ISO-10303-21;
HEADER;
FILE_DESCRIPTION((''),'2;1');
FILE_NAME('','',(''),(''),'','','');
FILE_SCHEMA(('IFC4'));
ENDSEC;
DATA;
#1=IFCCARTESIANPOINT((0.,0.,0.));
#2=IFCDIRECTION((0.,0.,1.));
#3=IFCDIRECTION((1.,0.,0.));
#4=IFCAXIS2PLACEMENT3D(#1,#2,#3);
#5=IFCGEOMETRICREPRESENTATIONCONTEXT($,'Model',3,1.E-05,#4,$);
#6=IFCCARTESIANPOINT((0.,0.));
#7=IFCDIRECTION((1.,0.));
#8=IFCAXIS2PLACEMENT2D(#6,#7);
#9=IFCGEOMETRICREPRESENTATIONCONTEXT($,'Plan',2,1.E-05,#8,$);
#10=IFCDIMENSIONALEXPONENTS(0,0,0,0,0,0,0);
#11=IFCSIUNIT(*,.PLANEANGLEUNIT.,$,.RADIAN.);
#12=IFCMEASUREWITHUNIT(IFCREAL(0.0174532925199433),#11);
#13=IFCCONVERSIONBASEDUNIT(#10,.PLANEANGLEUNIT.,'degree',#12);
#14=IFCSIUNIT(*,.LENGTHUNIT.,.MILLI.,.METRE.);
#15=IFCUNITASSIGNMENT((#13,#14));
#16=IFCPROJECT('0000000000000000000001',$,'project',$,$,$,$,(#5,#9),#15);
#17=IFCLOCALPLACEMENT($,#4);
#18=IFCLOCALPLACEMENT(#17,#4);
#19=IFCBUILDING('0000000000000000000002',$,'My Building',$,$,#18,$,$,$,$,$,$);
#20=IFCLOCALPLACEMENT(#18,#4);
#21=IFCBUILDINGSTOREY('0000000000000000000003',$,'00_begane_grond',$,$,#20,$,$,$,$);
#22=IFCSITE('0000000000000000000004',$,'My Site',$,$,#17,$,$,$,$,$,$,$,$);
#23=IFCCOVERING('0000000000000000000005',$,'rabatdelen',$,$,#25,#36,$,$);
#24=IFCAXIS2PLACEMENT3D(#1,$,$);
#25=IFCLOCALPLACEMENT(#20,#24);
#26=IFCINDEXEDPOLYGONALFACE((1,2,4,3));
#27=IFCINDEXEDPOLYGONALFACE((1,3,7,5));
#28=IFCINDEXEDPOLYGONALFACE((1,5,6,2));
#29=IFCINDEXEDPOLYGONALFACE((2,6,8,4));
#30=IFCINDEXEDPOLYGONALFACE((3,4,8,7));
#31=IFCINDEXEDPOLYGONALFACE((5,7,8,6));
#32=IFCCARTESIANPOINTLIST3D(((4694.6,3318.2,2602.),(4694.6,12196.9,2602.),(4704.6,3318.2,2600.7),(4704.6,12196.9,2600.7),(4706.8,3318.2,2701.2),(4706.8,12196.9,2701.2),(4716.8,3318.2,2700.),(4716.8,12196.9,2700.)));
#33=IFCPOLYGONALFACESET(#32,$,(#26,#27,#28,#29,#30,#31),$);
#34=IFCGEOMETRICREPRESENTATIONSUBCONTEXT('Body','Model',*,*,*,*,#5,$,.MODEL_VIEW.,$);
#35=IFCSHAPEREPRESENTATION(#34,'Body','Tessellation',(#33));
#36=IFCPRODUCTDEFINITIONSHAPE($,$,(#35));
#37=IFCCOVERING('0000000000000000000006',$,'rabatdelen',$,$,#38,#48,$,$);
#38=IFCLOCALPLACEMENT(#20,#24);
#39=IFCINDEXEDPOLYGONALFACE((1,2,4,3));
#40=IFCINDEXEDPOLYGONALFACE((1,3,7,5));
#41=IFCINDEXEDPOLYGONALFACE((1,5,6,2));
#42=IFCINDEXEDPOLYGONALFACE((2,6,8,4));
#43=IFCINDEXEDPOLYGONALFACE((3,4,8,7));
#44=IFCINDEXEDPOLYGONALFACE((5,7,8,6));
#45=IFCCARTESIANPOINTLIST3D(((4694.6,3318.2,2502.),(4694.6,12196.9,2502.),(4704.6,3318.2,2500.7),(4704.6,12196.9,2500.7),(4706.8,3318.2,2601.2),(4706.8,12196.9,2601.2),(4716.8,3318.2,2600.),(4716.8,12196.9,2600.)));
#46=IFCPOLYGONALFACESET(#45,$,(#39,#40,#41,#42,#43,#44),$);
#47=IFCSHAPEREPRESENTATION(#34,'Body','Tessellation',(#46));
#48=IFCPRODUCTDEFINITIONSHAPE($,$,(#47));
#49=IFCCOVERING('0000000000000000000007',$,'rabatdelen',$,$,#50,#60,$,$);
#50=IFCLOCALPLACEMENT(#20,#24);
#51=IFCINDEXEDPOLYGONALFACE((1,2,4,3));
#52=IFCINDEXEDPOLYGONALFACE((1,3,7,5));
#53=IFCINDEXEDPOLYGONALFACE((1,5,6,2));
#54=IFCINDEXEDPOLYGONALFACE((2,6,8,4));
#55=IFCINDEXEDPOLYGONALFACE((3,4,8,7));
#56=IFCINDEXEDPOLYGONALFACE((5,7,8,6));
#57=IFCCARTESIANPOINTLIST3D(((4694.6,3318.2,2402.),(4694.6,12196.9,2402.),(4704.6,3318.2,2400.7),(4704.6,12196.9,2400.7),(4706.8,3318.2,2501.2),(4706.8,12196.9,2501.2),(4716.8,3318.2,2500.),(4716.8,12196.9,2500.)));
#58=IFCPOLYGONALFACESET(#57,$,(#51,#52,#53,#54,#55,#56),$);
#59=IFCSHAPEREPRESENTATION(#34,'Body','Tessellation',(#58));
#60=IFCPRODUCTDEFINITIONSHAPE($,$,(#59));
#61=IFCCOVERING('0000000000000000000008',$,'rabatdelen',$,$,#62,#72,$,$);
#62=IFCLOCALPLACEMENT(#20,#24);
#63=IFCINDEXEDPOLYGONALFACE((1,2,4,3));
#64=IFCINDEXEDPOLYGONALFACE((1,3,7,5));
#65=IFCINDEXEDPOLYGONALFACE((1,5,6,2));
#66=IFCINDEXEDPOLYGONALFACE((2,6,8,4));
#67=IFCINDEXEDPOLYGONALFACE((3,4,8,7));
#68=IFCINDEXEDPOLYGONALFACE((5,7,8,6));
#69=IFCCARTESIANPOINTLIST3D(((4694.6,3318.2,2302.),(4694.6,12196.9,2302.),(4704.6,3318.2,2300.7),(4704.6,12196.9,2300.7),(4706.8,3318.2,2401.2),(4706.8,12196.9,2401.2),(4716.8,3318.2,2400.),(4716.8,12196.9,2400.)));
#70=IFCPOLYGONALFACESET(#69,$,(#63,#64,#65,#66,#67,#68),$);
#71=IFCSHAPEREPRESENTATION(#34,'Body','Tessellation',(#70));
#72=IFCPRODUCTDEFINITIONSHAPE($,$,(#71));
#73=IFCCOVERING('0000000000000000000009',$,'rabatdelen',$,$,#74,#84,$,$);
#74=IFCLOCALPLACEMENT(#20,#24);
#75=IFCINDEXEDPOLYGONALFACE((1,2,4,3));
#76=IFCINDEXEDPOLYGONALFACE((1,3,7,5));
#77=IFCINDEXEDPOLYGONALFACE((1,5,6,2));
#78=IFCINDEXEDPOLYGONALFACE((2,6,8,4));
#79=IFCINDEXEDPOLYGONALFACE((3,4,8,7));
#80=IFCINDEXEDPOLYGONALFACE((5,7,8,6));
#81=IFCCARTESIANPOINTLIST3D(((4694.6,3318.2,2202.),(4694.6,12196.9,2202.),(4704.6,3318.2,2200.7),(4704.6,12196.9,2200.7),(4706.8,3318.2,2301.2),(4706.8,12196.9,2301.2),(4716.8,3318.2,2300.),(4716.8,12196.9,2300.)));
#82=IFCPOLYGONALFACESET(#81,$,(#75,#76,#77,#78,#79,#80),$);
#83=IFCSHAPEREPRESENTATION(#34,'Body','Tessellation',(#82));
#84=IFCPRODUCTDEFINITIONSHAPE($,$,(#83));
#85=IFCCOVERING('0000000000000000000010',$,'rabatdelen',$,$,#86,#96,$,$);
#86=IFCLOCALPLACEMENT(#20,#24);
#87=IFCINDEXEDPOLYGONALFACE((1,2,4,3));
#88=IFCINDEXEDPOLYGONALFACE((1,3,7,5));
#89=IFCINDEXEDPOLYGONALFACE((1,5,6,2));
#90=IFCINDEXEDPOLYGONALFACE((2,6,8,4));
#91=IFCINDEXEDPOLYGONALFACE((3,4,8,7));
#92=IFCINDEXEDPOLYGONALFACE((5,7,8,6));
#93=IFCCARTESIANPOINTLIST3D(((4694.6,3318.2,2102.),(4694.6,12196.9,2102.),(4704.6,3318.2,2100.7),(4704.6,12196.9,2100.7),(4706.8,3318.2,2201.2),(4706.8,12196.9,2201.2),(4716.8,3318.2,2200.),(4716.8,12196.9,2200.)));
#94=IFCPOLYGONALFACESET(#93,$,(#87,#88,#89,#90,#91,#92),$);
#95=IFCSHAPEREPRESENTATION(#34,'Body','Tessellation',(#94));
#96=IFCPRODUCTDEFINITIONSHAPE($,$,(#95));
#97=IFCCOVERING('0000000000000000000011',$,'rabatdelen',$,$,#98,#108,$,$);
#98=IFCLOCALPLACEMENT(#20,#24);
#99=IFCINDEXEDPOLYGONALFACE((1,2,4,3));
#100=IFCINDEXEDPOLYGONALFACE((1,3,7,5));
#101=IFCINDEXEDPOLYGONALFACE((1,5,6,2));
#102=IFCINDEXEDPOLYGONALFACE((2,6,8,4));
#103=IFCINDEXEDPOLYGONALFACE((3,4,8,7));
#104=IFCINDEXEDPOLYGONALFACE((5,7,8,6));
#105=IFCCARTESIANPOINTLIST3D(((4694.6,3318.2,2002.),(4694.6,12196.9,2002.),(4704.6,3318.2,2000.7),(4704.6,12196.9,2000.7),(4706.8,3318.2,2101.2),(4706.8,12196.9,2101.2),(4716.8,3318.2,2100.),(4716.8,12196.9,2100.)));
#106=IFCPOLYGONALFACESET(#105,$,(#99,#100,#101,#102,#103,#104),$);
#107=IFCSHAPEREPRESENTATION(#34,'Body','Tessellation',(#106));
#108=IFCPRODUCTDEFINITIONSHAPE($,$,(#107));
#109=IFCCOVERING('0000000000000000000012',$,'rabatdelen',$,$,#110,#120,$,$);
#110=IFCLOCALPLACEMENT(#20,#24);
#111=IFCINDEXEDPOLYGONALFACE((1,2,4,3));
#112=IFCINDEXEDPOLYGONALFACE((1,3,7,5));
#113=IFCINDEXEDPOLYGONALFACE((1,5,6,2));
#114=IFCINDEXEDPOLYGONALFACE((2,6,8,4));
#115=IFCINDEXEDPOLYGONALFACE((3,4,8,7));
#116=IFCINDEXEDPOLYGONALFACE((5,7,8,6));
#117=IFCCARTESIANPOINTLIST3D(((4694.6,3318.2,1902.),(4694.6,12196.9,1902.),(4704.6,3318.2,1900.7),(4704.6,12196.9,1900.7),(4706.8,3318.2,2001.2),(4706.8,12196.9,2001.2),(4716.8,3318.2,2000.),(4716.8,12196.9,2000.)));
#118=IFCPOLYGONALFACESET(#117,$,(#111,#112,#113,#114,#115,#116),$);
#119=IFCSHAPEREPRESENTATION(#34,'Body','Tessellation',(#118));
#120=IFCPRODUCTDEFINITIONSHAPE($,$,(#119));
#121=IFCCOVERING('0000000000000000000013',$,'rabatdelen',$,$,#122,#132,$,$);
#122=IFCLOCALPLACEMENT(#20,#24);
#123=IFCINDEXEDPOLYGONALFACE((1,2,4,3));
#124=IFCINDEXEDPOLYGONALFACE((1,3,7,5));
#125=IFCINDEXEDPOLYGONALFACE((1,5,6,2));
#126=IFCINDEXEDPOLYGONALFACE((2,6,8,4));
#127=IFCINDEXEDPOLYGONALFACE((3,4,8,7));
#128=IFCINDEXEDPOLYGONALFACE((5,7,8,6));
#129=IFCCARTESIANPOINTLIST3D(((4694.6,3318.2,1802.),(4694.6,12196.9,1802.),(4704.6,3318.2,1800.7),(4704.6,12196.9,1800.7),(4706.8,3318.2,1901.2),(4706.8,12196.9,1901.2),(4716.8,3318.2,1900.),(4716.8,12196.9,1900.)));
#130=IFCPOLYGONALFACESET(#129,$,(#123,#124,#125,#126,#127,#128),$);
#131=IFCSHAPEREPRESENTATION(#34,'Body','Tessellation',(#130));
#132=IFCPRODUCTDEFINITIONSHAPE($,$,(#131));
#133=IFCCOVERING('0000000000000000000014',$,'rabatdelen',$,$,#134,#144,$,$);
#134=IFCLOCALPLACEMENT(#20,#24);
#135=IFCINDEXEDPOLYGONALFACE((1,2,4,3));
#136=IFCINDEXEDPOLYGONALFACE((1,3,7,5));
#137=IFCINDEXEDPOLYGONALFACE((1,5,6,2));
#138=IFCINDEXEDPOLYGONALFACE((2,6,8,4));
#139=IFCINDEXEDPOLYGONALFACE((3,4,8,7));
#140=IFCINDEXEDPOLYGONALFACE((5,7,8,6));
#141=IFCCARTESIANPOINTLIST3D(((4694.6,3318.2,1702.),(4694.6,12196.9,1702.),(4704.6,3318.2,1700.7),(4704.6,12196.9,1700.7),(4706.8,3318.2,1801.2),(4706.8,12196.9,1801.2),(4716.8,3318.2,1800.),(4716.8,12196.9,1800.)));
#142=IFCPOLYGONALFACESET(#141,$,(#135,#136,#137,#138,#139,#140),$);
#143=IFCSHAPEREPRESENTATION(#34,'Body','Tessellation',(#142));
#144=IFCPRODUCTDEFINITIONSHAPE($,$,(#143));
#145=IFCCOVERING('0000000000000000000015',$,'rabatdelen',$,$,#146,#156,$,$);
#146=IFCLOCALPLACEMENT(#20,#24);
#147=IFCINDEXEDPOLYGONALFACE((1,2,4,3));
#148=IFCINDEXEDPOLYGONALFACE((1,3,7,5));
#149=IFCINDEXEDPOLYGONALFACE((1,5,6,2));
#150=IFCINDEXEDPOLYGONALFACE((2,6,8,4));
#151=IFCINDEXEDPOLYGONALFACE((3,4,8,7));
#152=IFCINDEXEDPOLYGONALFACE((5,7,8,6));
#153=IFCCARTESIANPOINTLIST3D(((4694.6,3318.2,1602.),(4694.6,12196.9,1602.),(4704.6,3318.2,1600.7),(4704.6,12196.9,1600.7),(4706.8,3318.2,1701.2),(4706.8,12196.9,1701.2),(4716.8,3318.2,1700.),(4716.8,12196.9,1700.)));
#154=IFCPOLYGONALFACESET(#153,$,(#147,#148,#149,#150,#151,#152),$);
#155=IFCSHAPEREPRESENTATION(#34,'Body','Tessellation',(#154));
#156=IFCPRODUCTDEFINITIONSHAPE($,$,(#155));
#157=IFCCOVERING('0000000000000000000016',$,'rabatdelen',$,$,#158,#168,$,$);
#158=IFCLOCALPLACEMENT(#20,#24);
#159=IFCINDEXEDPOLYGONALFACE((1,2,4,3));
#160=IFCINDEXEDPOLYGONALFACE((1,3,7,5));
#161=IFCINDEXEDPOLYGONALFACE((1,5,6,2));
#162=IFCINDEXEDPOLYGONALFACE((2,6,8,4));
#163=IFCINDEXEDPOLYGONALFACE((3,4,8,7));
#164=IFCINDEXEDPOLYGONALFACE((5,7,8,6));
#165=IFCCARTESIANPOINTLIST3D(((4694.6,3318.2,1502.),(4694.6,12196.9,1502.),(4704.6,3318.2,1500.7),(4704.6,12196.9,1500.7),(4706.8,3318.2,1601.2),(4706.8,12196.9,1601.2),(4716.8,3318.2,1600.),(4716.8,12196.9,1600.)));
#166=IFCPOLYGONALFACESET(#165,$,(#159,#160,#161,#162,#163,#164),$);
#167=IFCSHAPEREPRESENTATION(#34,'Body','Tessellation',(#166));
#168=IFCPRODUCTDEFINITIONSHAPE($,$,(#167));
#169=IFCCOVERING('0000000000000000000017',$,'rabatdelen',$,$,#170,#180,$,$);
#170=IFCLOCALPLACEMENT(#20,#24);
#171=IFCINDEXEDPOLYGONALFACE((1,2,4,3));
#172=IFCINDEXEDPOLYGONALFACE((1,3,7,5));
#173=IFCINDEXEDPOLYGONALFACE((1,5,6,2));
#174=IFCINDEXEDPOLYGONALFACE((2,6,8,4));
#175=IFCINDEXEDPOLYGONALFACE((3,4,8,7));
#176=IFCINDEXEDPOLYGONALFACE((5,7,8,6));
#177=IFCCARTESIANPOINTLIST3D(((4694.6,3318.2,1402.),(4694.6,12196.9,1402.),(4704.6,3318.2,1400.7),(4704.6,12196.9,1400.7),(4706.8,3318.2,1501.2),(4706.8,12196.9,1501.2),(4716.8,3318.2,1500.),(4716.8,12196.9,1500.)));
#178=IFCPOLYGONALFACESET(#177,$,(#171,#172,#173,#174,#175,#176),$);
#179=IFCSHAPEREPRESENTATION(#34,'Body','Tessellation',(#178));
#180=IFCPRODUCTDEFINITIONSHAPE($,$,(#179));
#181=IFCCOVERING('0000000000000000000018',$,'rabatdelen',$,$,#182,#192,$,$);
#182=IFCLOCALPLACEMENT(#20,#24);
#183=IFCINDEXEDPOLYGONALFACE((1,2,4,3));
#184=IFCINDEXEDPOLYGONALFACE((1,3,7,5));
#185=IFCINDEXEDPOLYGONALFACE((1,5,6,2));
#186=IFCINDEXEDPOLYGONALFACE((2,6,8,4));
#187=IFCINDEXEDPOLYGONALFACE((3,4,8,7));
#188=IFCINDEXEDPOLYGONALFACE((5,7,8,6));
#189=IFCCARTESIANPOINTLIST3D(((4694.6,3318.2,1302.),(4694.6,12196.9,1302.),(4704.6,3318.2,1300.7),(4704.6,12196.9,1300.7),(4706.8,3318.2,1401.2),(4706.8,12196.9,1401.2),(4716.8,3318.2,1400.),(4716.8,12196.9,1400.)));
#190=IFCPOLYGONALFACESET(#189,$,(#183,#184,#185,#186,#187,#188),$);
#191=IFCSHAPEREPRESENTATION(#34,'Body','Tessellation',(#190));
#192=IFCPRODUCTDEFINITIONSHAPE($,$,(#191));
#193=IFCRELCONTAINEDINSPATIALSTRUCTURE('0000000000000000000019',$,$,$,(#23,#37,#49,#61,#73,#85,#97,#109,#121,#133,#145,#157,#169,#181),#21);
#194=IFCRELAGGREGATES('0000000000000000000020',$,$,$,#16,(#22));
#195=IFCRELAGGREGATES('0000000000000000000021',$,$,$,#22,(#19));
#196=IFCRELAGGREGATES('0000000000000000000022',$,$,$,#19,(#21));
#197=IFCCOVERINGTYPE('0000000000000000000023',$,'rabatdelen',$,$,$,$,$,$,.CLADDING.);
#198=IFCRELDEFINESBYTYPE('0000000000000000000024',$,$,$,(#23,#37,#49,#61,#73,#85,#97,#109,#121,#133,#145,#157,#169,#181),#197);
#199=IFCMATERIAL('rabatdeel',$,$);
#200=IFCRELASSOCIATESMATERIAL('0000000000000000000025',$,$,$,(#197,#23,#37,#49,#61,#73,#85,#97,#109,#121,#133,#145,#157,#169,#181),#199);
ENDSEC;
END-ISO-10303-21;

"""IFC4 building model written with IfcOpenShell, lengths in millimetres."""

from ifc_helpers import new_model, entity, si_unit, converted_unit, frame, origin_with_axes, origin_2d_with_axis, place, context, subcontext, project, spatial, rectangle, extrude, material, material_profile, profile_set, profile_usage, type_object, element, save


model = new_model("IFC4")

# Units and contexts
model_context = context("Model", 3, precision=1e-05, world=origin_with_axes())
plan_context = context("Plan", 2, precision=1e-05, world=origin_2d_with_axis())
body_context = subcontext(model_context, "Body", "Model", "MODEL_VIEW")
ifc_project = project(units=[converted_unit("PLANEANGLEUNIT", "degree", entity("IfcReal", 0.0174532925199433), si_unit("PLANEANGLEUNIT", "RADIAN"), dimensions=[0, 0, 0, 0, 0, 0, 0]), si_unit("LENGTHUNIT", "METRE", prefix="MILLI")], contexts=[model_context, plan_context])

# Site, building, storey
site_placement = place(None, origin_with_axes())
site = spatial("IfcSite", under=ifc_project, at=site_placement, Name="My Site")
building_placement = place(site_placement, origin_with_axes())
building = spatial("IfcBuilding", under=site, at=building_placement, Name="My Building")
storey_placement = place(building_placement, origin_with_axes())
storey = spatial("IfcBuildingStorey", under=building, at=storey_placement, Name="00_begane_grond")

# Coverings
ifc_material_1 = material(Name="rabatdeel")
ifc_material_profile_1 = material_profile(ifc_material_1, rectangle(XDim=10.0, YDim=100.0))
ifc_profile_set_1 = profile_set([ifc_material_profile_1])
covering_type = type_object("IfcCoveringType", Name="rabatdelen", PredefinedType="CLADDING", material=ifc_profile_set_1)
ifc_profile_usage_1 = profile_usage(ifc_profile_set_1, cardinal=7)
covering_1_placement = place(storey_placement, frame((4716.8, 12196.9, 2700.0), z_axis=(0.0, -1.0, 0.0), x_axis=(0.992546, 0.0, -0.121869)))
element("IfcCovering", 1, at=covering_1_placement, inside=storey, type_object=covering_type, material=ifc_profile_usage_1, Name="rabatdelen", context=body_context, shape_type="SweptSolid", body=[
    extrude(rectangle(XDim=10.0, YDim=100.0), frame((-5.0, -50.0, 0.0), z_axis=(0.0, 0.0, 1.0), x_axis=(1.0, 0.0, 0.0)), (0.0, 0.0, 1.0), 8878.8),
])
ifc_profile_usage_2 = profile_usage(ifc_profile_set_1, cardinal=7)
covering_2_placement = place(storey_placement, frame((4716.8, 12196.9, 2600.0), z_axis=(0.0, -1.0, 0.0), x_axis=(0.992546, 0.0, -0.121869)))
element("IfcCovering", 2, at=covering_2_placement, inside=storey, type_object=covering_type, material=ifc_profile_usage_2, Name="rabatdelen", context=body_context, shape_type="SweptSolid", body=[
    extrude(rectangle(XDim=10.0, YDim=100.0), frame((-5.0, -50.0, 0.0), z_axis=(0.0, 0.0, 1.0), x_axis=(1.0, 0.0, 0.0)), (0.0, 0.0, 1.0), 8878.8),
])
ifc_profile_usage_3 = profile_usage(ifc_profile_set_1, cardinal=7)
covering_3_placement = place(storey_placement, frame((4716.8, 12196.9, 2500.0), z_axis=(0.0, -1.0, 0.0), x_axis=(0.992546, 0.0, -0.121869)))
element("IfcCovering", 3, at=covering_3_placement, inside=storey, type_object=covering_type, material=ifc_profile_usage_3, Name="rabatdelen", context=body_context, shape_type="SweptSolid", body=[
    extrude(rectangle(XDim=10.0, YDim=100.0), frame((-5.0, -50.0, 0.0), z_axis=(0.0, 0.0, 1.0), x_axis=(1.0, 0.0, 0.0)), (0.0, 0.0, 1.0), 8878.8),
])
ifc_profile_usage_4 = profile_usage(ifc_profile_set_1, cardinal=7)
covering_4_placement = place(storey_placement, frame((4716.8, 12196.9, 2400.0), z_axis=(0.0, -1.0, 0.0), x_axis=(0.992546, 0.0, -0.121869)))
element("IfcCovering", 4, at=covering_4_placement, inside=storey, type_object=covering_type, material=ifc_profile_usage_4, Name="rabatdelen", context=body_context, shape_type="SweptSolid", body=[
    extrude(rectangle(XDim=10.0, YDim=100.0), frame((-5.0, -50.0, 0.0), z_axis=(0.0, 0.0, 1.0), x_axis=(1.0, 0.0, 0.0)), (0.0, 0.0, 1.0), 8878.8),
])
ifc_profile_usage_5 = profile_usage(ifc_profile_set_1, cardinal=7)
covering_5_placement = place(storey_placement, frame((4716.8, 12196.9, 2300.0), z_axis=(0.0, -1.0, 0.0), x_axis=(0.992546, 0.0, -0.121869)))
element("IfcCovering", 5, at=covering_5_placement, inside=storey, type_object=covering_type, material=ifc_profile_usage_5, Name="rabatdelen", context=body_context, shape_type="SweptSolid", body=[
    extrude(rectangle(XDim=10.0, YDim=100.0), frame((-5.0, -50.0, 0.0), z_axis=(0.0, 0.0, 1.0), x_axis=(1.0, 0.0, 0.0)), (0.0, 0.0, 1.0), 8878.8),
])
ifc_profile_usage_6 = profile_usage(ifc_profile_set_1, cardinal=7)
covering_6_placement = place(storey_placement, frame((4716.8, 12196.9, 2200.0), z_axis=(0.0, -1.0, 0.0), x_axis=(0.992546, 0.0, -0.121869)))
element("IfcCovering", 6, at=covering_6_placement, inside=storey, type_object=covering_type, material=ifc_profile_usage_6, Name="rabatdelen", context=body_context, shape_type="SweptSolid", body=[
    extrude(rectangle(XDim=10.0, YDim=100.0), frame((-5.0, -50.0, 0.0), z_axis=(0.0, 0.0, 1.0), x_axis=(1.0, 0.0, 0.0)), (0.0, 0.0, 1.0), 8878.8),
])
ifc_profile_usage_7 = profile_usage(ifc_profile_set_1, cardinal=7)
covering_7_placement = place(storey_placement, frame((4716.8, 12196.9, 2100.0), z_axis=(0.0, -1.0, 0.0), x_axis=(0.992546, 0.0, -0.121869)))
element("IfcCovering", 7, at=covering_7_placement, inside=storey, type_object=covering_type, material=ifc_profile_usage_7, Name="rabatdelen", context=body_context, shape_type="SweptSolid", body=[
    extrude(rectangle(XDim=10.0, YDim=100.0), frame((-5.0, -50.0, 0.0), z_axis=(0.0, 0.0, 1.0), x_axis=(1.0, 0.0, 0.0)), (0.0, 0.0, 1.0), 8878.8),
])
ifc_profile_usage_8 = profile_usage(ifc_profile_set_1, cardinal=7)
covering_8_placement = place(storey_placement, frame((4716.8, 12196.9, 2000.0), z_axis=(0.0, -1.0, 0.0), x_axis=(0.992546, 0.0, -0.121869)))
element("IfcCovering", 8, at=covering_8_placement, inside=storey, type_object=covering_type, material=ifc_profile_usage_8, Name="rabatdelen", context=body_context, shape_type="SweptSolid", body=[
    extrude(rectangle(XDim=10.0, YDim=100.0), frame((-5.0, -50.0, 0.0), z_axis=(0.0, 0.0, 1.0), x_axis=(1.0, 0.0, 0.0)), (0.0, 0.0, 1.0), 8878.8),
])
ifc_profile_usage_9 = profile_usage(ifc_profile_set_1, cardinal=7)
covering_9_placement = place(storey_placement, frame((4716.8, 12196.9, 1900.0), z_axis=(0.0, -1.0, 0.0), x_axis=(0.992546, 0.0, -0.121869)))
element("IfcCovering", 9, at=covering_9_placement, inside=storey, type_object=covering_type, material=ifc_profile_usage_9, Name="rabatdelen", context=body_context, shape_type="SweptSolid", body=[
    extrude(rectangle(XDim=10.0, YDim=100.0), frame((-5.0, -50.0, 0.0), z_axis=(0.0, 0.0, 1.0), x_axis=(1.0, 0.0, 0.0)), (0.0, 0.0, 1.0), 8878.8),
])
ifc_profile_usage_10 = profile_usage(ifc_profile_set_1, cardinal=7)
covering_10_placement = place(storey_placement, frame((4716.8, 12196.9, 1800.0), z_axis=(0.0, -1.0, 0.0), x_axis=(0.992546, 0.0, -0.121869)))
element("IfcCovering", 10, at=covering_10_placement, inside=storey, type_object=covering_type, material=ifc_profile_usage_10, Name="rabatdelen", context=body_context, shape_type="SweptSolid", body=[
    extrude(rectangle(XDim=10.0, YDim=100.0), frame((-5.0, -50.0, 0.0), z_axis=(0.0, 0.0, 1.0), x_axis=(1.0, 0.0, 0.0)), (0.0, 0.0, 1.0), 8878.8),
])
ifc_profile_usage_11 = profile_usage(ifc_profile_set_1, cardinal=7)
covering_11_placement = place(storey_placement, frame((4716.8, 12196.9, 1700.0), z_axis=(0.0, -1.0, 0.0), x_axis=(0.992546, 0.0, -0.121869)))
element("IfcCovering", 11, at=covering_11_placement, inside=storey, type_object=covering_type, material=ifc_profile_usage_11, Name="rabatdelen", context=body_context, shape_type="SweptSolid", body=[
    extrude(rectangle(XDim=10.0, YDim=100.0), frame((-5.0, -50.0, 0.0), z_axis=(0.0, 0.0, 1.0), x_axis=(1.0, 0.0, 0.0)), (0.0, 0.0, 1.0), 8878.8),
])
ifc_profile_usage_12 = profile_usage(ifc_profile_set_1, cardinal=7)
covering_12_placement = place(storey_placement, frame((4716.8, 12196.9, 1600.0), z_axis=(0.0, -1.0, 0.0), x_axis=(0.992546, 0.0, -0.121869)))
element("IfcCovering", 12, at=covering_12_placement, inside=storey, type_object=covering_type, material=ifc_profile_usage_12, Name="rabatdelen", context=body_context, shape_type="SweptSolid", body=[
    extrude(rectangle(XDim=10.0, YDim=100.0), frame((-5.0, -50.0, 0.0), z_axis=(0.0, 0.0, 1.0), x_axis=(1.0, 0.0, 0.0)), (0.0, 0.0, 1.0), 8878.8),
])
ifc_profile_usage_13 = profile_usage(ifc_profile_set_1, cardinal=7)
covering_13_placement = place(storey_placement, frame((4716.8, 12196.9, 1500.0), z_axis=(0.0, -1.0, 0.0), x_axis=(0.992546, 0.0, -0.121869)))
element("IfcCovering", 13, at=covering_13_placement, inside=storey, type_object=covering_type, material=ifc_profile_usage_13, Name="rabatdelen", context=body_context, shape_type="SweptSolid", body=[
    extrude(rectangle(XDim=10.0, YDim=100.0), frame((-5.0, -50.0, 0.0), z_axis=(0.0, 0.0, 1.0), x_axis=(1.0, 0.0, 0.0)), (0.0, 0.0, 1.0), 8878.8),
])
ifc_profile_usage_14 = profile_usage(ifc_profile_set_1, cardinal=7)
covering_14_placement = place(storey_placement, frame((4716.8, 12196.9, 1400.0), z_axis=(0.0, -1.0, 0.0), x_axis=(0.992546, 0.0, -0.121869)))
element("IfcCovering", 14, at=covering_14_placement, inside=storey, type_object=covering_type, material=ifc_profile_usage_14, Name="rabatdelen", context=body_context, shape_type="SweptSolid", body=[
    extrude(rectangle(XDim=10.0, YDim=100.0), frame((-5.0, -50.0, 0.0), z_axis=(0.0, 0.0, 1.0), x_axis=(1.0, 0.0, 0.0)), (0.0, 0.0, 1.0), 8878.8),
])

save(model, "model.ifc")
